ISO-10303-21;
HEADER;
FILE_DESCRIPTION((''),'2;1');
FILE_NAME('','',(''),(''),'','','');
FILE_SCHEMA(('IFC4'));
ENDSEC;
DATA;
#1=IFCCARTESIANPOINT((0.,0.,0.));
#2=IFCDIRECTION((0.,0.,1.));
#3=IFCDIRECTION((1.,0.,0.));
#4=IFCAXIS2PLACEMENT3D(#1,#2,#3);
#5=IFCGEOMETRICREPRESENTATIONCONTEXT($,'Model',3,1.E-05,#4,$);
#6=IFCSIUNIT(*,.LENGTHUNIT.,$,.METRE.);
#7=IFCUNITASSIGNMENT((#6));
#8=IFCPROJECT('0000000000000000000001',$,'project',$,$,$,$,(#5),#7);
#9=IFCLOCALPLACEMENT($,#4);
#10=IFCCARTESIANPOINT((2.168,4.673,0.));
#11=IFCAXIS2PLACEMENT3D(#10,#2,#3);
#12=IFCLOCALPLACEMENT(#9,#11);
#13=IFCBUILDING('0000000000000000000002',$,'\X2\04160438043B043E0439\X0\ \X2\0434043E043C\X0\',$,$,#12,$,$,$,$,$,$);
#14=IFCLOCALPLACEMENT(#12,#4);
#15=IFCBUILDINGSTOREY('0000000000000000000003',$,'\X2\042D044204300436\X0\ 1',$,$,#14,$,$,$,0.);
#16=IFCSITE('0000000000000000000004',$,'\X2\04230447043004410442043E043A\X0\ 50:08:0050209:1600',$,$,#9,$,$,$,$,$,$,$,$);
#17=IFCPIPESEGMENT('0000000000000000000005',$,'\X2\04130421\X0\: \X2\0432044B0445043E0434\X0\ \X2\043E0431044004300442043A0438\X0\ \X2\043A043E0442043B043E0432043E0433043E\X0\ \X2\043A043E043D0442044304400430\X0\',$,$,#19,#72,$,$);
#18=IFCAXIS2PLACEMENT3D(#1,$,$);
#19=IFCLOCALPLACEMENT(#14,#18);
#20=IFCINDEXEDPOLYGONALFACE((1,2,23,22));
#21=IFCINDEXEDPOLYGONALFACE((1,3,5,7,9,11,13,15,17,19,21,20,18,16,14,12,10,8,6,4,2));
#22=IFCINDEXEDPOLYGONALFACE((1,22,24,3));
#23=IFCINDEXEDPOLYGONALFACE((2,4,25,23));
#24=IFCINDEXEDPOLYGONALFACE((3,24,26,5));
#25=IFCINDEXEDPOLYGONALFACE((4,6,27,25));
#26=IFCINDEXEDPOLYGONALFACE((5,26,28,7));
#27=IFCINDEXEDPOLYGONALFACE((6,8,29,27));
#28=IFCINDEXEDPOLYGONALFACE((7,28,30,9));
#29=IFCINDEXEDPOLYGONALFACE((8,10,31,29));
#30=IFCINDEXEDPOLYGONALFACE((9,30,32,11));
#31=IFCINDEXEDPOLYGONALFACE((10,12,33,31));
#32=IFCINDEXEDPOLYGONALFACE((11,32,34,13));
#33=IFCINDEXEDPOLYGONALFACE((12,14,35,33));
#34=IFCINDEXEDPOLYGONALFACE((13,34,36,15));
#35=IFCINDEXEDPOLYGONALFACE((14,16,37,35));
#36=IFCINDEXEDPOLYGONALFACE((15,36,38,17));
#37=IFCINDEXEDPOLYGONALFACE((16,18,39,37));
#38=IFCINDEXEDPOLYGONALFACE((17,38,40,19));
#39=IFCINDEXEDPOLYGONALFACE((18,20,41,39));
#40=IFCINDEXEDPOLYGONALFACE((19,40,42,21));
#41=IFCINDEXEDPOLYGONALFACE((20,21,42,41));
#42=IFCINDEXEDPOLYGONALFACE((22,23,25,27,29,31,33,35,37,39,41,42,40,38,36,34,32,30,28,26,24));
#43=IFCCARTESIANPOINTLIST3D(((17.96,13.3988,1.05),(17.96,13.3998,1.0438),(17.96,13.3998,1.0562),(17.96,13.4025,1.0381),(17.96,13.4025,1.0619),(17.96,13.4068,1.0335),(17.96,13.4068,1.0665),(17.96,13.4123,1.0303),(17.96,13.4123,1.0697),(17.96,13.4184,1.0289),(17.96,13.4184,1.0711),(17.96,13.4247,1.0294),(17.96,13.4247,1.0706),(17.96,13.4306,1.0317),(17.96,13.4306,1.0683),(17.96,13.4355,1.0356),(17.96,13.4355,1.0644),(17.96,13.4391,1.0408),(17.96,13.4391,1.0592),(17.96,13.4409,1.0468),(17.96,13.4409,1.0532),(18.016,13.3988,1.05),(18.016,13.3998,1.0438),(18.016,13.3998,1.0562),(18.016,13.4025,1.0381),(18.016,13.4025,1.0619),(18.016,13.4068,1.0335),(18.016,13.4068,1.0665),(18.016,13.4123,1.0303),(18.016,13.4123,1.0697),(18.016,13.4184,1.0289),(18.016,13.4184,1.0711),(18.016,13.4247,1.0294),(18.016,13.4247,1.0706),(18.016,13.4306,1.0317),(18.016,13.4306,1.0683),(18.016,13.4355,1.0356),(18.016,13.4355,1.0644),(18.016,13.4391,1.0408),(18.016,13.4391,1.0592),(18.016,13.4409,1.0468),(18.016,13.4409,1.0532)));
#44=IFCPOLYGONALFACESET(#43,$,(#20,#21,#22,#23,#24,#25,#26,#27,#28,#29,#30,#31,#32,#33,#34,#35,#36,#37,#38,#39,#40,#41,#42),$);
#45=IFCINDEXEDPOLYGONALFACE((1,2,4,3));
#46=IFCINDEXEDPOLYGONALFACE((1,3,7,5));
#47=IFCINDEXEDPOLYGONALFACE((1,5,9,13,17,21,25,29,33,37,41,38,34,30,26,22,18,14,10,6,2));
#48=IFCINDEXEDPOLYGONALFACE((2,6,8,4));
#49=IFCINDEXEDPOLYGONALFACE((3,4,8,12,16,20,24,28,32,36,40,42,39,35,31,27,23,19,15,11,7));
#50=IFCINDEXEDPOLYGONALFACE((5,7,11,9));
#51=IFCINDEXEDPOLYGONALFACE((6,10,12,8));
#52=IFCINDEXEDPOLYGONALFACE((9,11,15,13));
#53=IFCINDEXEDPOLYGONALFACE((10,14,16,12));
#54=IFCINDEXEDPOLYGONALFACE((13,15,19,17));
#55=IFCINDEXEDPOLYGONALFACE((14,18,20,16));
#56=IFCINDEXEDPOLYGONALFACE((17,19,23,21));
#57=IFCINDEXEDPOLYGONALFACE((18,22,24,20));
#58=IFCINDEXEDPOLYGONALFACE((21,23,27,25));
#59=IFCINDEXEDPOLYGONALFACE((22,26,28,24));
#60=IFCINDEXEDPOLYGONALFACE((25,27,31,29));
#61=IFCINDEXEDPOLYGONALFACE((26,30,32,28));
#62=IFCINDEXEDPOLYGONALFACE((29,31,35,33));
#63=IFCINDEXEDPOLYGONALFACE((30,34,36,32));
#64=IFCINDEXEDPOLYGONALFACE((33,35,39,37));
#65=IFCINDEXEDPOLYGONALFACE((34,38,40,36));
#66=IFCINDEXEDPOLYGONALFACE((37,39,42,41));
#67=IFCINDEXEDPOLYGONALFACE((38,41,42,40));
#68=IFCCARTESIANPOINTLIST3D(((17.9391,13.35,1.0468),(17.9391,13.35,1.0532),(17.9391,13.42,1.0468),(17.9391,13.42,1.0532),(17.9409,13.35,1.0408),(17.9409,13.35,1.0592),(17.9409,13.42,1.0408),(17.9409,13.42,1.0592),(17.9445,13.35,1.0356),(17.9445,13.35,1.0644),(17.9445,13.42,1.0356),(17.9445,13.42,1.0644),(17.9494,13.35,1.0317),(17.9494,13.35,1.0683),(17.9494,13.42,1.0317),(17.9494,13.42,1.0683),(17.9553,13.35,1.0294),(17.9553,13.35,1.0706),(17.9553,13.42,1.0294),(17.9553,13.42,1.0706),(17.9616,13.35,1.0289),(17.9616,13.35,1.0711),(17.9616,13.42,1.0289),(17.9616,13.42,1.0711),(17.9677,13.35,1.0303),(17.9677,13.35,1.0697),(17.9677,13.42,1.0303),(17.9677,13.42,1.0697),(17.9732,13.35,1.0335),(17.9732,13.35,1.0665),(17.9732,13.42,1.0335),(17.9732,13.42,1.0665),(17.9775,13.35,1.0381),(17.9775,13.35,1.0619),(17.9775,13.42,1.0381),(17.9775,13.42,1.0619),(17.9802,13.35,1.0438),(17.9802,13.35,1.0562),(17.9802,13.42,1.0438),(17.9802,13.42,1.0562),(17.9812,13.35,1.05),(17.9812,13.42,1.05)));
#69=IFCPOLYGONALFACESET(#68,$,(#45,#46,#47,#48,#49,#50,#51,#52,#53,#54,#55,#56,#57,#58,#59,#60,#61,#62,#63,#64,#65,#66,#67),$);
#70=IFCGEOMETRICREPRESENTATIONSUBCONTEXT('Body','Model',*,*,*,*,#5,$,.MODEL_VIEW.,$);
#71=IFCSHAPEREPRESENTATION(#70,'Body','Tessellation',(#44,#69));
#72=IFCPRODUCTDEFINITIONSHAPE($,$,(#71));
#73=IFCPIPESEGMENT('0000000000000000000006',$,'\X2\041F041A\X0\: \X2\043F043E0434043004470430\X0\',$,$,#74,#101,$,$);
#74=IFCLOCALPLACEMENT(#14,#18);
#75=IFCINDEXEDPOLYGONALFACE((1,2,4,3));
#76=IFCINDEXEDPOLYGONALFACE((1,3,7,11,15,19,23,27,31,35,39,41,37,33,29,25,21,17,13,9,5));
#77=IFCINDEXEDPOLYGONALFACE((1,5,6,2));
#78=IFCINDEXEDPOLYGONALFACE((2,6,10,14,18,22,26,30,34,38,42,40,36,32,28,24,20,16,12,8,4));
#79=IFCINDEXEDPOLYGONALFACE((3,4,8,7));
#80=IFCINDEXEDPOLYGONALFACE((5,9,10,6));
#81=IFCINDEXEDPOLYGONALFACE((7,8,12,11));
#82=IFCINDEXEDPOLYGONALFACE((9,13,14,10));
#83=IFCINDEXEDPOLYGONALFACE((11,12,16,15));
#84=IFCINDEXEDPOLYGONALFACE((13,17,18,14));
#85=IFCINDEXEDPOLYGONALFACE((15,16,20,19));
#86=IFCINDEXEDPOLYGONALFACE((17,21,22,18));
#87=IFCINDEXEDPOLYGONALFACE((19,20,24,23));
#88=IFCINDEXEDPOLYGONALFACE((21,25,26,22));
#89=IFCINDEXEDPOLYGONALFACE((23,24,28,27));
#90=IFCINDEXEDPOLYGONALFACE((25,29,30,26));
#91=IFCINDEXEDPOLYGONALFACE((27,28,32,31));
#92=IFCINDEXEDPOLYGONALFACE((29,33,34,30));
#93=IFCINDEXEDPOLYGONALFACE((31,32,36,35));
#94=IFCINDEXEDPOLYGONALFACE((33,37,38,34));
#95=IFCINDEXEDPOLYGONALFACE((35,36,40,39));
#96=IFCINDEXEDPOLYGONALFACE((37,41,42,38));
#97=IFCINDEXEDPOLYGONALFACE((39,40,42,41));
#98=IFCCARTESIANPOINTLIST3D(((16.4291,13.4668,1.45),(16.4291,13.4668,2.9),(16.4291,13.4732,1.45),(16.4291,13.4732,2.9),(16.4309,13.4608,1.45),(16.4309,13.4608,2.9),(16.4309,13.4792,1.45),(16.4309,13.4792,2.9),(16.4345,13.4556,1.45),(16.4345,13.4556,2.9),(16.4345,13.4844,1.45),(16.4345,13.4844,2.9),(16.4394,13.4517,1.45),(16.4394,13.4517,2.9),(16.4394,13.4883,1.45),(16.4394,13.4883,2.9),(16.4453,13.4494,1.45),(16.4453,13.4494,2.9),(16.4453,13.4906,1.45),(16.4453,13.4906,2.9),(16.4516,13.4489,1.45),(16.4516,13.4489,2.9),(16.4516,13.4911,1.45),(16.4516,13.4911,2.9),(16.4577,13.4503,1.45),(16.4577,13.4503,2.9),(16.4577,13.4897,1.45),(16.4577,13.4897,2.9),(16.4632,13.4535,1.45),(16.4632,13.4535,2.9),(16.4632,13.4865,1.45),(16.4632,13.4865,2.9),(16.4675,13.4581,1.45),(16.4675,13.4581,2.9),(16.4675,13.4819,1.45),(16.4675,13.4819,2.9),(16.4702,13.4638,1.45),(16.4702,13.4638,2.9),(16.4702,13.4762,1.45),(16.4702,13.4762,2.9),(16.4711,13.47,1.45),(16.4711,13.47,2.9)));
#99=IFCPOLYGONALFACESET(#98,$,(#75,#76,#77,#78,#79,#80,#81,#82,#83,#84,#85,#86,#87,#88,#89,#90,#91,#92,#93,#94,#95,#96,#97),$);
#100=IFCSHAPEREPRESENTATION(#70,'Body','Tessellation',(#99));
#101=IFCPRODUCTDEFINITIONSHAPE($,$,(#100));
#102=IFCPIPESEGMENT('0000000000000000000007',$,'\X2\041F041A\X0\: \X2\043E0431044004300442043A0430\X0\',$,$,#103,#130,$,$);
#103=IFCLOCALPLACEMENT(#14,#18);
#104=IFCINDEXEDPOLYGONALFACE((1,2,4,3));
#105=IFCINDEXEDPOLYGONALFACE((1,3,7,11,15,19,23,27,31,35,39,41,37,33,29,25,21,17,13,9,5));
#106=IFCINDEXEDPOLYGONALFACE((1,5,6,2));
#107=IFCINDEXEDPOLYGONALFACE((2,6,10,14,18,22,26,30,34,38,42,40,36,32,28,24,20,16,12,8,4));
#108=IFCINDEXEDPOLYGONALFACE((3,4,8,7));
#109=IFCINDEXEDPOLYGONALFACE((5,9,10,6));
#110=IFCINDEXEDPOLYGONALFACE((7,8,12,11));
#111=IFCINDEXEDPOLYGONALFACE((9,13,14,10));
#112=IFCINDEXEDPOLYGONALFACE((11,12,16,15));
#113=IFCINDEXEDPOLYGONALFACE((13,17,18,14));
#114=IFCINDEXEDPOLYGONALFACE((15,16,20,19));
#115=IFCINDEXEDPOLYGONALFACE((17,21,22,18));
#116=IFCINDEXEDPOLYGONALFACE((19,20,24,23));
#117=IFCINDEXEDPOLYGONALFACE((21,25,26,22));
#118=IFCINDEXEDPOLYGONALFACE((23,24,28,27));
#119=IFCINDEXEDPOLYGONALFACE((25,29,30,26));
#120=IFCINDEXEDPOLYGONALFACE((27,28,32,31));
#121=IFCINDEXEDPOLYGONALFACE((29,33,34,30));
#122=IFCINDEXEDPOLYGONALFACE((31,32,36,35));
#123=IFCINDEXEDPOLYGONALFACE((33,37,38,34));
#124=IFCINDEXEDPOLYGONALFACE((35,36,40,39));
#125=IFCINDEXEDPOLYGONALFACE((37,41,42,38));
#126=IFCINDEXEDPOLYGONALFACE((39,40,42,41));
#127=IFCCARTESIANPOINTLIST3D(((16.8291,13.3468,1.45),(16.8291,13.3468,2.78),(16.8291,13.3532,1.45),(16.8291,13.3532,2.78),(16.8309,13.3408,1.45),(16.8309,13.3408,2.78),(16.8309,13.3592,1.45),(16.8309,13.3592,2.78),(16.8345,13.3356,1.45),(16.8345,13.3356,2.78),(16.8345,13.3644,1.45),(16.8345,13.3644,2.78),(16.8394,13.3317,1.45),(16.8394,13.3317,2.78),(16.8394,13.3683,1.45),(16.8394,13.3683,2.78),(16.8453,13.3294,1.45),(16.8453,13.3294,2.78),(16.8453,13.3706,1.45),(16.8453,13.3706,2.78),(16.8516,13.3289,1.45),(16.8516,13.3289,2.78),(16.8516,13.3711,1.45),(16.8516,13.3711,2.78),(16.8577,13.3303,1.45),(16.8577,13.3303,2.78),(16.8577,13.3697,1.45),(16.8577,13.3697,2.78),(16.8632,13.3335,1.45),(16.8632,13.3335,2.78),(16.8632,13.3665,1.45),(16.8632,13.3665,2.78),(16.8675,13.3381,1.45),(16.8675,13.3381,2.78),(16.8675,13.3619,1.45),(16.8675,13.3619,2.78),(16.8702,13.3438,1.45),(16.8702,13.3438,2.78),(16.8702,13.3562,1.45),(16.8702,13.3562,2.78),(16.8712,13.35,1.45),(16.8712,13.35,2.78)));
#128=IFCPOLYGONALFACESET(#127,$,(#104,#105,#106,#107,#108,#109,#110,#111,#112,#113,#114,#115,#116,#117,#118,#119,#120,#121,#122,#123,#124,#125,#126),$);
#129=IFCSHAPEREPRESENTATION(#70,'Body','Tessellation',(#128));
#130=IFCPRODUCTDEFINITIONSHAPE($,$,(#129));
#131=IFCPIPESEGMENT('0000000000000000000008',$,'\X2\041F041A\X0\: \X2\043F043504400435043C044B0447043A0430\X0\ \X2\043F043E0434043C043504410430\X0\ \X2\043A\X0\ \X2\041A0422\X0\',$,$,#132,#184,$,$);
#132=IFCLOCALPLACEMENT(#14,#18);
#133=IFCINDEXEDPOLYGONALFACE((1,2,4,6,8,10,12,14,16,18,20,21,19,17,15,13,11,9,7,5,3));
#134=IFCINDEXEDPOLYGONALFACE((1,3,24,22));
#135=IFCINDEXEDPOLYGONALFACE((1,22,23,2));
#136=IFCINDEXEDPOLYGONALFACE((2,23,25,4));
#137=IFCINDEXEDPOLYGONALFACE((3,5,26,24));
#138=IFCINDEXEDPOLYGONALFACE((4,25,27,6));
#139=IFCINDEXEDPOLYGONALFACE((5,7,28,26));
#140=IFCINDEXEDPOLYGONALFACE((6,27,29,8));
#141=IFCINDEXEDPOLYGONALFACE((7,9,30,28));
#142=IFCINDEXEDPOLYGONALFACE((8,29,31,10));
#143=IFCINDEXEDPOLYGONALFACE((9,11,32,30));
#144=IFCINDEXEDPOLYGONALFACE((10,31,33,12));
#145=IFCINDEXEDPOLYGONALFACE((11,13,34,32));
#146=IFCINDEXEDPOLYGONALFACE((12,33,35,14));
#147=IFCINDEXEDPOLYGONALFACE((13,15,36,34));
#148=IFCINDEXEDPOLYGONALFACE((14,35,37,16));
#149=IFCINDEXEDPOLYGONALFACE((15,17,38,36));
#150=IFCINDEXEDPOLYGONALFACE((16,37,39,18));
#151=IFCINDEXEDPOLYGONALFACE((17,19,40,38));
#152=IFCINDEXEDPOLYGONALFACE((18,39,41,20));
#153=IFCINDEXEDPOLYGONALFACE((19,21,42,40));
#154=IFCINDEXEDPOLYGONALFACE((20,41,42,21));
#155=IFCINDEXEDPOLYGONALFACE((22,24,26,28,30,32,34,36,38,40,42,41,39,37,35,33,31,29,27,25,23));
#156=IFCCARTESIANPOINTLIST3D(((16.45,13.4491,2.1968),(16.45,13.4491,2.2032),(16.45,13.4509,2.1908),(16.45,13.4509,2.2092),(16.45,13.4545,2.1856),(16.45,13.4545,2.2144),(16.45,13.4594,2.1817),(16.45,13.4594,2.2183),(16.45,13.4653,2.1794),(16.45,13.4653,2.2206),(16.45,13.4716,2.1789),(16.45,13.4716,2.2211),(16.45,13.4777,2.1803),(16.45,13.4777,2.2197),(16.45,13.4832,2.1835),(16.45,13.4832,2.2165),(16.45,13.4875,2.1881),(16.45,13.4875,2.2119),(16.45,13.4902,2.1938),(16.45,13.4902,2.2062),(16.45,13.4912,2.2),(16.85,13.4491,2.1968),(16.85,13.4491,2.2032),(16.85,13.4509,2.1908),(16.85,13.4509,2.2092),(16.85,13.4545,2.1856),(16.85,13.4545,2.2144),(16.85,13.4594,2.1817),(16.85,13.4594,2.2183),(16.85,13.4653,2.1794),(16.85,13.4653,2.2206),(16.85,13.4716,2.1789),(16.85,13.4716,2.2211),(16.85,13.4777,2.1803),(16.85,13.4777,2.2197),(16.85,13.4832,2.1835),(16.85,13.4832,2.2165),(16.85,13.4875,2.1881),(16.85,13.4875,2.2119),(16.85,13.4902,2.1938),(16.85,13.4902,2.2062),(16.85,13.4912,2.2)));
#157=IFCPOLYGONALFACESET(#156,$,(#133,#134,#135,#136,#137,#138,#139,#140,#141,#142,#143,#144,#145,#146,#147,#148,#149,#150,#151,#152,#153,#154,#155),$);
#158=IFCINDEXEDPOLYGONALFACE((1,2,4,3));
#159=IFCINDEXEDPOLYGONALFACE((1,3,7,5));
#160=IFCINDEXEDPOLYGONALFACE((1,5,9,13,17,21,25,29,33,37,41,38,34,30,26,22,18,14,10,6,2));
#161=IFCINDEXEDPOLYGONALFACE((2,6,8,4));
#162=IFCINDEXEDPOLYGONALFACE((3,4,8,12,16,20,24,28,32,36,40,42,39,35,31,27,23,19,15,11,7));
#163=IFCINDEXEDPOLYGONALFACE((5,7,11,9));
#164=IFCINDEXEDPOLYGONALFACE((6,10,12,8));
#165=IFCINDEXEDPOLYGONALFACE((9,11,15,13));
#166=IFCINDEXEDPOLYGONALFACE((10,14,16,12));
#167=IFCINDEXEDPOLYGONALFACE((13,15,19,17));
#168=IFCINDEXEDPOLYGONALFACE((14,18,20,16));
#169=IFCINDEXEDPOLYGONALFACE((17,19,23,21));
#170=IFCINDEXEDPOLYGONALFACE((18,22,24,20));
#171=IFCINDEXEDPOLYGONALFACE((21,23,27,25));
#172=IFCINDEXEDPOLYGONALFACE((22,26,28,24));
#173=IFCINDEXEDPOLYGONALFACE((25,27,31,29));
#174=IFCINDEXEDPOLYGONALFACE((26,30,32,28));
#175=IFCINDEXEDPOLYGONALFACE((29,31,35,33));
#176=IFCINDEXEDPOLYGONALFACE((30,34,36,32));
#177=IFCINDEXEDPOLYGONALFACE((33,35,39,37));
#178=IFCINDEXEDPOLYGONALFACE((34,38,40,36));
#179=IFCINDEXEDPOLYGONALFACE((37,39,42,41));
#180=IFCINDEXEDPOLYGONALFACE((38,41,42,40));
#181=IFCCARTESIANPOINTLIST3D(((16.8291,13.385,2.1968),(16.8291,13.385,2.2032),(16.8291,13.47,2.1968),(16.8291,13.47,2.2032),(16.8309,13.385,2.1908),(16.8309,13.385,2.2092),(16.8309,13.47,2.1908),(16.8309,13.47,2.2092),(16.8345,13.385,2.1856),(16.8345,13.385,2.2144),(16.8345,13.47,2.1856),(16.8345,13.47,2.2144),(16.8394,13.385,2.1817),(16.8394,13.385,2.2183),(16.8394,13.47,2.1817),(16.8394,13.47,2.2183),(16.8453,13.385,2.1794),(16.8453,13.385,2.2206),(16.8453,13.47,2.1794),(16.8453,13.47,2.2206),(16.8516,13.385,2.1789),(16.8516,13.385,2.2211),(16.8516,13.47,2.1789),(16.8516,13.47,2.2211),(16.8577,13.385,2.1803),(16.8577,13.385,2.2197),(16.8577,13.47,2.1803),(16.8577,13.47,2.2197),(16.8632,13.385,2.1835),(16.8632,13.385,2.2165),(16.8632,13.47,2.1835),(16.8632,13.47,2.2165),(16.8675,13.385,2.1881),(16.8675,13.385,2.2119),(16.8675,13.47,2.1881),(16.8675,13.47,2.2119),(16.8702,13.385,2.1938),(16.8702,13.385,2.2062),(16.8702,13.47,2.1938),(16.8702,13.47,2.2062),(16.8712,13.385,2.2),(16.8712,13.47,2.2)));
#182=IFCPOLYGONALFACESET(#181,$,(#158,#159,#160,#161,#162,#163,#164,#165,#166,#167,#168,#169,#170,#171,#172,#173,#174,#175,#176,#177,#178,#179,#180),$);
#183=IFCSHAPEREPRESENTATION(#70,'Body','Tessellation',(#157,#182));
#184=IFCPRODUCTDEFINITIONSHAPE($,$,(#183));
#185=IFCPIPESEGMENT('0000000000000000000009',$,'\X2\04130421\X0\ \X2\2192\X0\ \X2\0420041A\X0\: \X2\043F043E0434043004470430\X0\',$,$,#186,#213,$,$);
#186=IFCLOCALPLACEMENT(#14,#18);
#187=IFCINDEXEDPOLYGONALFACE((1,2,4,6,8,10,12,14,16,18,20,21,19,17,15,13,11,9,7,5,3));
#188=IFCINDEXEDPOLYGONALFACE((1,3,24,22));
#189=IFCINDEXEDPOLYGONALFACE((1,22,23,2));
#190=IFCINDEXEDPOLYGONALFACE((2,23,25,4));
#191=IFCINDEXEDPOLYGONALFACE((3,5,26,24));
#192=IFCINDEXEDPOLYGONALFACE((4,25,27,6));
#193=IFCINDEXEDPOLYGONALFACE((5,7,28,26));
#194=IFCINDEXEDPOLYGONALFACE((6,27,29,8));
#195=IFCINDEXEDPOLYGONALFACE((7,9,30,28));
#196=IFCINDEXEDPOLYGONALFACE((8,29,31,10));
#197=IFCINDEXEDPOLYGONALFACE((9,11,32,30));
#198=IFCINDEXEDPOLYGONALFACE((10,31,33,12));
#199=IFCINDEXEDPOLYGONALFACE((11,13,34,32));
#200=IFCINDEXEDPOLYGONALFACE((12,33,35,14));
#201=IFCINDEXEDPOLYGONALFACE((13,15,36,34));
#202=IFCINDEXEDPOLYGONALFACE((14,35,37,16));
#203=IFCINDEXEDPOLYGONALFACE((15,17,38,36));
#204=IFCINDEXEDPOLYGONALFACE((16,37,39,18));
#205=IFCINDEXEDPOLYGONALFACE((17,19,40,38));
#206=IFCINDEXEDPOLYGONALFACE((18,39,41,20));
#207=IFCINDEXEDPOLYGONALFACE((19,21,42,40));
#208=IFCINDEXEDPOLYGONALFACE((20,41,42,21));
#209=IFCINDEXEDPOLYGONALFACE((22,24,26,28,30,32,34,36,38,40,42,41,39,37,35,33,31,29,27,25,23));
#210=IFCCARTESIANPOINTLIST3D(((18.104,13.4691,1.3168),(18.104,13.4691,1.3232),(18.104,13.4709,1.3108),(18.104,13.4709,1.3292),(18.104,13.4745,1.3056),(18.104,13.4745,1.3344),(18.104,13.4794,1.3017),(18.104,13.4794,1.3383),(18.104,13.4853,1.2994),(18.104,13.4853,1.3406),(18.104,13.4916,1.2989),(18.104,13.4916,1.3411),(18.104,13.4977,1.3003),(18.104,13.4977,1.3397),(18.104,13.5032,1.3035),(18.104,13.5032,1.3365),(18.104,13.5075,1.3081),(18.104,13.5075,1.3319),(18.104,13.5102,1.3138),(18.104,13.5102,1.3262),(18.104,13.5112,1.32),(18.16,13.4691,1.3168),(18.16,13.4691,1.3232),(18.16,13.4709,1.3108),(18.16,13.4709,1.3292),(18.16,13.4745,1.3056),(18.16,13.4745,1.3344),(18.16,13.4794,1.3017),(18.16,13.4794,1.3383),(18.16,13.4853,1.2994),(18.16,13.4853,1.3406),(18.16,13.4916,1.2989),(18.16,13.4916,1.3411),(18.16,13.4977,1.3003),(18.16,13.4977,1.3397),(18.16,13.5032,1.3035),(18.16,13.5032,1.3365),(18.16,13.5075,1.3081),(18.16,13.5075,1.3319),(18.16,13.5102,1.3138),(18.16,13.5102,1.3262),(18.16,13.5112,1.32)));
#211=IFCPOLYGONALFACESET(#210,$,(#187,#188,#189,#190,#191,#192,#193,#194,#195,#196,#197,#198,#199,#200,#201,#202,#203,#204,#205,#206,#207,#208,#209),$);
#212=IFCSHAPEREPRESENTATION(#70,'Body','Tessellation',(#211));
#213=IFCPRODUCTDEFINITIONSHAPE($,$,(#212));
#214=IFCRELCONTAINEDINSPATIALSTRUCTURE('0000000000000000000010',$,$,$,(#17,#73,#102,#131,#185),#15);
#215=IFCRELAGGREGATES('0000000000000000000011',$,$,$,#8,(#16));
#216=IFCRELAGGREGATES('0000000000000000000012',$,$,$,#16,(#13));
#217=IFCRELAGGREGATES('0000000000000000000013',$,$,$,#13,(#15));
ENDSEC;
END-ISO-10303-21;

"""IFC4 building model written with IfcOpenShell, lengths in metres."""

from ifc_helpers import new_model, si_unit, frame, origin_with_axes, origin_2d, place, context, subcontext, project, spatial, circle, extrude, element, save


model = new_model("IFC4")

# Units and contexts
model_context = context("Model", 3, precision=1e-05, world=origin_with_axes())
body_context = subcontext(model_context, "Body", "Model", "MODEL_VIEW")
ifc_project = project(units=[si_unit("LENGTHUNIT", "METRE")], contexts=[model_context])

# Site, building, storey
site_placement = place(None, origin_with_axes())
site = spatial("IfcSite", under=ifc_project, at=site_placement, Name="Участок 50:08:0050209:1600")
building_placement = place(site_placement, frame((2.168, 4.673, 0.0), z_axis=(0.0, 0.0, 1.0), x_axis=(1.0, 0.0, 0.0)))
building = spatial("IfcBuilding", under=site, at=building_placement, Name="Жилой дом")
storey_placement = place(building_placement, origin_with_axes())
storey = spatial("IfcBuildingStorey", under=building, at=storey_placement, Name="Этаж 1", Elevation=0.0)

# Pipe segments
pipe_segment_1_placement = place(storey_placement, origin_with_axes())
element("IfcPipeSegment", 1, at=pipe_segment_1_placement, inside=storey, Name="ГС: выход обратки котлового контура", context=body_context, shape_type="SweptSolid", body=[
    extrude(circle(Radius=0.0211, at=origin_2d()), frame((18.016, 13.42, 1.05), z_axis=(-1.0, 0.0, 0.0), x_axis=(0.0, -1.0, 0.0)), (0.0, 0.0, 1.0), 0.056),
    extrude(circle(Radius=0.0211, at=origin_2d()), frame((17.96, 13.42, 1.05), z_axis=(0.0, -1.0, 0.0), x_axis=(1.0, 0.0, 0.0)), (0.0, 0.0, 1.0), 0.07),
])
pipe_segment_2_placement = place(storey_placement, origin_with_axes())
element("IfcPipeSegment", 2, at=pipe_segment_2_placement, inside=storey, Name="ПК: подача", context=body_context, shape_type="SweptSolid", body=[
    extrude(circle(Radius=0.0211, at=origin_2d()), frame((16.45, 13.47, 1.45), z_axis=(0.0, 0.0, 1.0), x_axis=(1.0, 0.0, 0.0)), (0.0, 0.0, 1.0), 1.45),
])
pipe_segment_3_placement = place(storey_placement, origin_with_axes())
element("IfcPipeSegment", 3, at=pipe_segment_3_placement, inside=storey, Name="ПК: обратка", context=body_context, shape_type="SweptSolid", body=[
    extrude(circle(Radius=0.0211, at=origin_2d()), frame((16.85, 13.35, 1.45), z_axis=(0.0, 0.0, 1.0), x_axis=(1.0, 0.0, 0.0)), (0.0, 0.0, 1.0), 1.33),
])
pipe_segment_4_placement = place(storey_placement, origin_with_axes())
element("IfcPipeSegment", 4, at=pipe_segment_4_placement, inside=storey, Name="ПК: перемычка подмеса к КТ", context=body_context, shape_type="SweptSolid", body=[
    extrude(circle(Radius=0.0211, at=origin_2d()), frame((16.45, 13.47, 2.2), z_axis=(1.0, 0.0, 0.0), x_axis=(0.0, 1.0, 0.0)), (0.0, 0.0, 1.0), 0.4),
    extrude(circle(Radius=0.0211, at=origin_2d()), frame((16.85, 13.47, 2.2), z_axis=(0.0, -1.0, 0.0), x_axis=(1.0, 0.0, 0.0)), (0.0, 0.0, 1.0), 0.085),
])
pipe_segment_5_placement = place(storey_placement, origin_with_axes())
element("IfcPipeSegment", 5, at=pipe_segment_5_placement, inside=storey, Name="ГС → РК: подача", context=body_context, shape_type="SweptSolid", body=[
    extrude(circle(Radius=0.0211, at=origin_2d()), frame((18.104, 13.49, 1.32), z_axis=(1.0, 0.0, 0.0), x_axis=(0.0, 1.0, 0.0)), (0.0, 0.0, 1.0), 0.056),
])

save(model, "model.ifc")
